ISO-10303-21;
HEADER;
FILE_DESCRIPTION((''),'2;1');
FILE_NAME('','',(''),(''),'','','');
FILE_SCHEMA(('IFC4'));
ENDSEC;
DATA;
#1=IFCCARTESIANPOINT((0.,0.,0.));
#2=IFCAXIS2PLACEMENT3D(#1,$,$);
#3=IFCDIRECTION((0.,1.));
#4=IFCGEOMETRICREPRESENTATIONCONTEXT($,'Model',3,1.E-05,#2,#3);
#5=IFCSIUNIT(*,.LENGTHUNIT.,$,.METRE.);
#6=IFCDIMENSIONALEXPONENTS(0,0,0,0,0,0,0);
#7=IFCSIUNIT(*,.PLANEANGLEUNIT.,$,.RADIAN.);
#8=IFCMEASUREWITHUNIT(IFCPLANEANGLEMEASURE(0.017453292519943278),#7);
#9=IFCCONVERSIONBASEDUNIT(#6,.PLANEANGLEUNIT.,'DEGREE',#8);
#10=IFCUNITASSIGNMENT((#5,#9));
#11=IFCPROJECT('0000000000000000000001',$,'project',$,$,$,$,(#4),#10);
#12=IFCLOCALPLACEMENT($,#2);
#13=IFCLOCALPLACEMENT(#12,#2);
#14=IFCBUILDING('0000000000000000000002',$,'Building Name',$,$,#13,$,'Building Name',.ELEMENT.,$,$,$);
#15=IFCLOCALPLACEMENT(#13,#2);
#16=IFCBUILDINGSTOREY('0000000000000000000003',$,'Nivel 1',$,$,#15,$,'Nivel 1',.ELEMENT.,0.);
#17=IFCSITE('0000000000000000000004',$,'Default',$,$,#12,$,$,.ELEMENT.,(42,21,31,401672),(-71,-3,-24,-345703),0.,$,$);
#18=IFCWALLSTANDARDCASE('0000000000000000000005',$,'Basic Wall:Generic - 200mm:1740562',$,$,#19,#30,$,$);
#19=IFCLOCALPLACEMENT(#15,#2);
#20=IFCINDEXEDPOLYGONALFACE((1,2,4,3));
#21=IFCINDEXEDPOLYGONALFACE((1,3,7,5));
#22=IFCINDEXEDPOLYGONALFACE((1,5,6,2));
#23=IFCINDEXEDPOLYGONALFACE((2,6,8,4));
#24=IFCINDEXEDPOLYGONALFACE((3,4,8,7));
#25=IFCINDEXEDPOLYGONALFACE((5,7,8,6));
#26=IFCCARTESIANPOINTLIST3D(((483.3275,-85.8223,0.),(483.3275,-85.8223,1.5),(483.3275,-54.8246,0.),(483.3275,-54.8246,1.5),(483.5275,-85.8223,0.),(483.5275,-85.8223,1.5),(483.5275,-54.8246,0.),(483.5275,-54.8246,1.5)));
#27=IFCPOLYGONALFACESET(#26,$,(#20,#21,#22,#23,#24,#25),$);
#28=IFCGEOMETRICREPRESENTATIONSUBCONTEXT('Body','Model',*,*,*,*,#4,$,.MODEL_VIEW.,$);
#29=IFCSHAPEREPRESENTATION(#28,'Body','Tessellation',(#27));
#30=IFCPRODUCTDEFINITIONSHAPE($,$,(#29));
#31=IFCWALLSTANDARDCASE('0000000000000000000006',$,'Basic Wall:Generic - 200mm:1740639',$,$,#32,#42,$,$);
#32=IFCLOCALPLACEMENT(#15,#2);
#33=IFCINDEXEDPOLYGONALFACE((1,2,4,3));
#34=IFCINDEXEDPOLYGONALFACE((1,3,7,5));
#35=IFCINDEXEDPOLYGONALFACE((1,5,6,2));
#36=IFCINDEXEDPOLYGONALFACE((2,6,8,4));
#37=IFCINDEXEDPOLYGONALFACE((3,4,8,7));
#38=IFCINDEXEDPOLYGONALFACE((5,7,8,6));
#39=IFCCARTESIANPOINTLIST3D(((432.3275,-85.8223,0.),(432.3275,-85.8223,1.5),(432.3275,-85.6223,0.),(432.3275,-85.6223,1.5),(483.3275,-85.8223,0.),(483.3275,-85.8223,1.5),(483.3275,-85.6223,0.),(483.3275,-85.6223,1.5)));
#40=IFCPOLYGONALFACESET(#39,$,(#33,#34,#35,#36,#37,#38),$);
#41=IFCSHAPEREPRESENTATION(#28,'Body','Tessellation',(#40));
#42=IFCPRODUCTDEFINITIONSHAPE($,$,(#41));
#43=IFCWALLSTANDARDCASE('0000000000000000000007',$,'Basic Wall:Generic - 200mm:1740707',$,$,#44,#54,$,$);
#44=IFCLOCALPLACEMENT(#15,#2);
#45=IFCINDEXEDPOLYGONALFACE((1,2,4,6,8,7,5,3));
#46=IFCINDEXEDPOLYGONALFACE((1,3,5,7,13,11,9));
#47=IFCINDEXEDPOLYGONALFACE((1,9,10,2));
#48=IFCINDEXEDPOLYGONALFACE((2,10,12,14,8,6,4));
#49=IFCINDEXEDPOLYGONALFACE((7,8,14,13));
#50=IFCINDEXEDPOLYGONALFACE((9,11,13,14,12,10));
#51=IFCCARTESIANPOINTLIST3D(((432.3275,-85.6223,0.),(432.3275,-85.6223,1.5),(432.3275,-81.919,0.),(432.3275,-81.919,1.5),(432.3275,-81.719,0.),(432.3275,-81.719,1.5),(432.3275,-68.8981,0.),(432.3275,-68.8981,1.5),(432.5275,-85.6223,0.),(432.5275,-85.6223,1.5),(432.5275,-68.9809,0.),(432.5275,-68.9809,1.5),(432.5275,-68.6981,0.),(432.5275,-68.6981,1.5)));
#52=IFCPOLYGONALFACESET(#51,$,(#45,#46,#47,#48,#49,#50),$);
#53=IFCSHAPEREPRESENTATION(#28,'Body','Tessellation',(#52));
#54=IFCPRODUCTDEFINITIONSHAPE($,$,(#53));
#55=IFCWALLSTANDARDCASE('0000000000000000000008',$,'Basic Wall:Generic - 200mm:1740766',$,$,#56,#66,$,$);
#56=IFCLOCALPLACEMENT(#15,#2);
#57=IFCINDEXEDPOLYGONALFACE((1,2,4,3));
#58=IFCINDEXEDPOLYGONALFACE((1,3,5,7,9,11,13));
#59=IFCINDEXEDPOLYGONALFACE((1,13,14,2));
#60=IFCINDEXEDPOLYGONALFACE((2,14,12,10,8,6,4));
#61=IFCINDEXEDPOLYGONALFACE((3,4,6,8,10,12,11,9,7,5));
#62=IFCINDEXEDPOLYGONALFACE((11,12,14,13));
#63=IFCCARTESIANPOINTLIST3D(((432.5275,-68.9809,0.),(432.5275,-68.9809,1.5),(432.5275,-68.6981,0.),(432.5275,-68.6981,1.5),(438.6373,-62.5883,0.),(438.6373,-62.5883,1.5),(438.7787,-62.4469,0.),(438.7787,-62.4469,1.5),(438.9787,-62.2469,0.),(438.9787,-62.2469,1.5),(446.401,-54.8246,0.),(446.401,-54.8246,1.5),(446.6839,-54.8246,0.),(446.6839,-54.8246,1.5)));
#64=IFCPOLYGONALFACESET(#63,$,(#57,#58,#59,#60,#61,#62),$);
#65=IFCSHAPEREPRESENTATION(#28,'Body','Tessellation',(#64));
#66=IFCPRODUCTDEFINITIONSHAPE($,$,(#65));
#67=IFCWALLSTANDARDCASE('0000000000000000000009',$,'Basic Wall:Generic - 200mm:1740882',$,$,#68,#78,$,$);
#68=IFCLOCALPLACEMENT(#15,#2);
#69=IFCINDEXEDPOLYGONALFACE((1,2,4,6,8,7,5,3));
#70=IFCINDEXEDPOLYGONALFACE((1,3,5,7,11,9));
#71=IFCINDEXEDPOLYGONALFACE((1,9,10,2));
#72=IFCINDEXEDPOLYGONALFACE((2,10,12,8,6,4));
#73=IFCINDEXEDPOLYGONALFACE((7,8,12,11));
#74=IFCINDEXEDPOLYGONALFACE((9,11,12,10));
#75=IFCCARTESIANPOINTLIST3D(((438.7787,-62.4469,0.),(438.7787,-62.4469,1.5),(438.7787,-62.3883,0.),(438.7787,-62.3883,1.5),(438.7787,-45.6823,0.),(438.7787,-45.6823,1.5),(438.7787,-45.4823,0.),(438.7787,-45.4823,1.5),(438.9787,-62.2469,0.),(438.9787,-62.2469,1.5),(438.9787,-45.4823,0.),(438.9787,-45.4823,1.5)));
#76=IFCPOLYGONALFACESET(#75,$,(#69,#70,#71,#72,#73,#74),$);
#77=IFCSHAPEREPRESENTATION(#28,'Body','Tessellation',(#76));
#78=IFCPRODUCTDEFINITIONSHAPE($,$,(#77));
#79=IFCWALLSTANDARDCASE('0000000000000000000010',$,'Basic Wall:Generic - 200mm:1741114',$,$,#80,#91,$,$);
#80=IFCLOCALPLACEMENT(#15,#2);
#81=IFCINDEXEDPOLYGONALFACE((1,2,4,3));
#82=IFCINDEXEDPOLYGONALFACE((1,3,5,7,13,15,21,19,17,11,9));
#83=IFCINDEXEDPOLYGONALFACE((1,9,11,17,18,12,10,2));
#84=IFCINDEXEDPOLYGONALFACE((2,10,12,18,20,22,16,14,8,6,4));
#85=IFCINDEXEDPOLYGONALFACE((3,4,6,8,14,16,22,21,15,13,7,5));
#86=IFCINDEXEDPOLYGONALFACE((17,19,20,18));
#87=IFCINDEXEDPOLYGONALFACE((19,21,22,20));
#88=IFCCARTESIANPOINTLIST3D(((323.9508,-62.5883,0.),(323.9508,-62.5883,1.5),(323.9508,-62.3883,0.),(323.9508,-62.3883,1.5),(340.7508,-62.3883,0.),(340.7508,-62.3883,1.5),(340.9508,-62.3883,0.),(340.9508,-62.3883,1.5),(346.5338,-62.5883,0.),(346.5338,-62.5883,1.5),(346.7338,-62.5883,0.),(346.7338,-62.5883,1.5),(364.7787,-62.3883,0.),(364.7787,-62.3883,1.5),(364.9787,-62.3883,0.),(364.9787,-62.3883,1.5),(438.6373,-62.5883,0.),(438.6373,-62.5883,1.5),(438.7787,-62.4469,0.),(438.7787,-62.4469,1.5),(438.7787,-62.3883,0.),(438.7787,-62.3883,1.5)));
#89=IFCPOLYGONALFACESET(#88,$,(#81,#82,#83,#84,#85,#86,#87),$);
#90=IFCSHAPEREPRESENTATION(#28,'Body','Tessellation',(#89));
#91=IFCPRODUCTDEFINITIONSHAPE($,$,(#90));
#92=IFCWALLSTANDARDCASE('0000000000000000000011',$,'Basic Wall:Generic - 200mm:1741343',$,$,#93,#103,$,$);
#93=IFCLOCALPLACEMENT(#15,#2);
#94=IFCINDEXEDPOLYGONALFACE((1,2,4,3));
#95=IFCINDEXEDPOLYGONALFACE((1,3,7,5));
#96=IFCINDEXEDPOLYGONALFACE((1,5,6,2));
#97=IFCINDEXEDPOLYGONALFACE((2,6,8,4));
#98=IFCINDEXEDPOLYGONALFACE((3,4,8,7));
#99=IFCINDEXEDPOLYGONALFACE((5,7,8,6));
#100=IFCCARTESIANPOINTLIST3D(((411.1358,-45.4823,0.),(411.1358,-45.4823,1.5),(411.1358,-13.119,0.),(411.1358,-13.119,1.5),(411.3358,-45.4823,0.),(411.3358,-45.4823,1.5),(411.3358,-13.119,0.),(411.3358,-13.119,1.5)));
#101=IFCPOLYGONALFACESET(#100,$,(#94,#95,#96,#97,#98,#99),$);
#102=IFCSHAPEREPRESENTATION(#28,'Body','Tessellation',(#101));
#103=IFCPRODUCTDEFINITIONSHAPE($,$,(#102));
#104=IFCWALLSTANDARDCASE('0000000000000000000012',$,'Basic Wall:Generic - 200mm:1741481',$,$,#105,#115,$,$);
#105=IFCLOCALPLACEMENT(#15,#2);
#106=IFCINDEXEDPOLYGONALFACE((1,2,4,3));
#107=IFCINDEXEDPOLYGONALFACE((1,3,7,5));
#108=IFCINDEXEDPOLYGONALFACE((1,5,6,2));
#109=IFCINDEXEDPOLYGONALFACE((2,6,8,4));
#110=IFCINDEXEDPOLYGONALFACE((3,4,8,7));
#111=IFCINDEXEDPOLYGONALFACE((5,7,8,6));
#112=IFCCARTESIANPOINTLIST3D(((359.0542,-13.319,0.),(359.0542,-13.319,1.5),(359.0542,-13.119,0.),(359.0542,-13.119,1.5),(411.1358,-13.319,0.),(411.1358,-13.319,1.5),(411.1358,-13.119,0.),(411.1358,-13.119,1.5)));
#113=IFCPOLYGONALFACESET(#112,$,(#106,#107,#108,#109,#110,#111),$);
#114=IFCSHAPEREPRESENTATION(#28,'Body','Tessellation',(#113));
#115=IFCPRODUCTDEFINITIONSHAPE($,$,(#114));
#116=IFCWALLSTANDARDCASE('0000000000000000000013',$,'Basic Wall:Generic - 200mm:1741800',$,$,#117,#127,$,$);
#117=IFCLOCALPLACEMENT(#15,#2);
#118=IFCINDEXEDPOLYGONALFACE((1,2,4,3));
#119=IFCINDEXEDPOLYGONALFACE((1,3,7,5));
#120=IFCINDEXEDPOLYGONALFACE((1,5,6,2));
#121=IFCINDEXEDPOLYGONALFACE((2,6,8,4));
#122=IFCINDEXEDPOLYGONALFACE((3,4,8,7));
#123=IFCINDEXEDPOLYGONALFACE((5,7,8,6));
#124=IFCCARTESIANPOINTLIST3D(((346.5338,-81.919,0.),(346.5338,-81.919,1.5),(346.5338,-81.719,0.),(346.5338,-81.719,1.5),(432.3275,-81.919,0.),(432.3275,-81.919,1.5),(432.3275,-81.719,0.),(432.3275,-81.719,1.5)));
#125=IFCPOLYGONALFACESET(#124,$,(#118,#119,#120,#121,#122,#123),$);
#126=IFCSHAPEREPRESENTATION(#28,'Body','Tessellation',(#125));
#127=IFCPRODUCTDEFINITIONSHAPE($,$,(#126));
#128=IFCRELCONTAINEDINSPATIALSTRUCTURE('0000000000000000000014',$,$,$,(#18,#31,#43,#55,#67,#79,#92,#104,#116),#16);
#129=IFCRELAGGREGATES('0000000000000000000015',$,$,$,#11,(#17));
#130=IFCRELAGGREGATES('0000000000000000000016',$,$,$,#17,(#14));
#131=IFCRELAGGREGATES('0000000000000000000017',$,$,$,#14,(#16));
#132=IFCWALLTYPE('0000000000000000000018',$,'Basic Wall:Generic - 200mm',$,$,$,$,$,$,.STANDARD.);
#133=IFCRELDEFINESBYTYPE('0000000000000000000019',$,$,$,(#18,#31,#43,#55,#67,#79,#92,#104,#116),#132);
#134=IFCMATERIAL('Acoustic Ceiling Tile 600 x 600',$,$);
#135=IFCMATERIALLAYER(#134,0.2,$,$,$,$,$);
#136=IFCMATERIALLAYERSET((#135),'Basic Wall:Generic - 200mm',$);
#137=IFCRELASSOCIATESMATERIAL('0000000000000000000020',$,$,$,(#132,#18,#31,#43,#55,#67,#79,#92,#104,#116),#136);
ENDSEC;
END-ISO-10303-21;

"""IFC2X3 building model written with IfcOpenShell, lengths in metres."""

from ifc_helpers import new_model, entity, si_unit, converted_unit, direction, frame, frame_2d, origin, place, context, subcontext, project, spatial, polyline, rectangle, outline, extrude, material, layer, layer_set, layer_usage, type_object, element, save


model = new_model("IFC2X3")

# Units and contexts
model_context = context("Model", 3, precision=1e-05, world=origin(), true_north=direction((0.0, 1.0)))
body_context = subcontext(model_context, "Body", "Model", "MODEL_VIEW")
ifc_project = project(units=[si_unit("LENGTHUNIT", "METRE"), converted_unit("PLANEANGLEUNIT", "DEGREE", entity("IfcPlaneAngleMeasure", 0.017453292519943278), si_unit("PLANEANGLEUNIT", "RADIAN"), dimensions=[0, 0, 0, 0, 0, 0, 0])], contexts=[model_context])

# Site, building, storey
site_placement = place(None, origin())
site = spatial("IfcSite", under=ifc_project, at=site_placement, Name="Default", CompositionType="ELEMENT", RefLatitude=(42, 21, 31, 401672), RefLongitude=(-71, -3, -24, -345703), RefElevation=0.0)
building_placement = place(site_placement, origin())
building = spatial("IfcBuilding", under=site, at=building_placement, Name="Building Name", LongName="Building Name", CompositionType="ELEMENT")
storey_placement = place(building_placement, origin())
storey = spatial("IfcBuildingStorey", under=building, at=storey_placement, Name="Nivel 1", LongName="Nivel 1", CompositionType="ELEMENT", Elevation=0.0)

# Walls
ifc_material_1 = material(Name="Acoustic Ceiling Tile 600 x 600")
ifc_layer = layer(ifc_material_1, 0.2)
ifc_layer_set = layer_set([ifc_layer], Name="Basic Wall:Generic - 200mm")
wall_type_1 = type_object("IfcWallType", Name="Basic Wall:Generic - 200mm", PredefinedType="STANDARD", material=ifc_layer_set)
ifc_layer_usage_1 = layer_usage(ifc_layer_set, "AXIS2", "NEGATIVE", 0.1)
wall_1_placement = place(storey_placement, frame((483.4275, -54.8246, 0.0), z_axis=(0.0, 0.0, 1.0), x_axis=(0.0, -1.0, 0.0)))
element("IfcWallStandardCase", 1, at=wall_1_placement, inside=storey, type_object=wall_type_1, material=ifc_layer_usage_1, Name="Basic Wall:Generic - 200mm:1740562", context=body_context, shape_type="SweptSolid", body=[
    extrude(rectangle(XDim=30.9978, YDim=0.2, at=frame_2d((15.4989, 0.0), x_axis=(-1.0, 0.0))), origin(), (0.0, 0.0, 1.0), 1.5),
])
ifc_layer_usage_2 = layer_usage(ifc_layer_set, "AXIS2", "NEGATIVE", 0.1)
wall_2_placement = place(storey_placement, frame((483.3275, -85.7223, 0.0), z_axis=(0.0, 0.0, 1.0), x_axis=(-1.0, 0.0, 0.0)))
element("IfcWallStandardCase", 2, at=wall_2_placement, inside=storey, type_object=wall_type_1, material=ifc_layer_usage_2, Name="Basic Wall:Generic - 200mm:1740639", context=body_context, shape_type="SweptSolid", body=[
    extrude(rectangle(XDim=51.0, YDim=0.2, at=frame_2d((25.5, 0.0), x_axis=(-1.0, 0.0))), origin(), (0.0, 0.0, 1.0), 1.5),
])
ifc_layer_usage_3 = layer_usage(ifc_layer_set, "AXIS2", "NEGATIVE", 0.1)
wall_3_placement = place(storey_placement, frame((432.4275, -85.6223, 0.0), z_axis=(0.0, 0.0, 1.0), x_axis=(0.0, 1.0, 0.0)))
element("IfcWallStandardCase", 3, at=wall_3_placement, inside=storey, type_object=wall_type_1, material=ifc_layer_usage_3, Name="Basic Wall:Generic - 200mm:1740707", context=body_context, shape_type="SweptSolid", body=[
    extrude(outline(polyline([(16.9243, -0.1), (16.7243, 0.1), (3.9033, 0.1), (3.7033, 0.1), (0.0, 0.1), (0.0, -0.1), (16.6414, -0.1), (16.9243, -0.1)])), origin(), (0.0, 0.0, 1.0), 1.5),
])
ifc_layer_usage_4 = layer_usage(ifc_layer_set, "AXIS2", "NEGATIVE", 0.1)
wall_4_placement = place(storey_placement, frame((432.4568, -68.9102, 0.0), z_axis=(0.0, 0.0, 1.0), x_axis=(0.707107, 0.707107, 0.0)))
element("IfcWallStandardCase", 4, at=wall_4_placement, inside=storey, type_object=wall_type_1, material=ifc_layer_usage_4, Name="Basic Wall:Generic - 200mm:1740766", context=body_context, shape_type="SweptSolid", body=[
    extrude(outline(polyline([(20.0201, -0.1), (19.8201, 0.1), (9.3234, 0.1), (9.0406, 0.1), (8.8406, 0.1), (0.2, 0.1), (0.0, -0.1), (20.0201, -0.1)])), origin(), (0.0, 0.0, 1.0), 1.5),
])
ifc_layer_usage_5 = layer_usage(ifc_layer_set, "AXIS2", "NEGATIVE", 0.1)
wall_5_placement = place(storey_placement, frame((438.8787, -45.4823, 0.0), z_axis=(0.0, 0.0, 1.0), x_axis=(0.0, -1.0, 0.0)))
element("IfcWallStandardCase", 5, at=wall_5_placement, inside=storey, type_object=wall_type_1, material=ifc_layer_usage_5, Name="Basic Wall:Generic - 200mm:1740882", context=body_context, shape_type="SweptSolid", body=[
    extrude(outline(polyline([(16.9646, -0.1), (16.7646, 0.1), (0.0, 0.1), (0.0, -0.1), (0.2, -0.1), (16.906, -0.1), (16.9646, -0.1)])), origin(), (0.0, 0.0, 1.0), 1.5),
])
ifc_layer_usage_6 = layer_usage(ifc_layer_set, "AXIS2", "NEGATIVE", 0.1)
wall_6_placement = place(storey_placement, frame((438.7787, -62.4883, 0.0), z_axis=(0.0, 0.0, 1.0), x_axis=(-1.0, 0.0, 0.0)))
element("IfcWallStandardCase", 6, at=wall_6_placement, inside=storey, type_object=wall_type_1, material=ifc_layer_usage_6, Name="Basic Wall:Generic - 200mm:1741114", context=body_context, shape_type="SweptSolid", body=[
    extrude(outline(polyline([(114.8279, -0.1), (114.8279, 0.1), (92.2449, 0.1), (92.0449, 0.1), (0.1414, 0.1), (0.0, -0.0414), (0.0, -0.1), (73.8, -0.1), (74.0, -0.1), (97.8279, -0.1), (98.0279, -0.1), (114.8279, -0.1)])), origin(), (0.0, 0.0, 1.0), 1.5),
])
ifc_layer_usage_7 = layer_usage(ifc_layer_set, "AXIS2", "NEGATIVE", 0.1)
wall_7_placement = place(storey_placement, frame((411.2358, -45.4823, 0.0), z_axis=(0.0, 0.0, 1.0), x_axis=(0.0, 1.0, 0.0)))
element("IfcWallStandardCase", 7, at=wall_7_placement, inside=storey, type_object=wall_type_1, material=ifc_layer_usage_7, Name="Basic Wall:Generic - 200mm:1741343", context=body_context, shape_type="SweptSolid", body=[
    extrude(rectangle(XDim=32.3633, YDim=0.2, at=frame_2d((16.1816, 0.0), x_axis=(-1.0, 0.0))), origin(), (0.0, 0.0, 1.0), 1.5),
])
ifc_layer_usage_8 = layer_usage(ifc_layer_set, "AXIS2", "NEGATIVE", 0.1)
wall_8_placement = place(storey_placement, frame((411.1358, -13.219, 0.0), z_axis=(0.0, 0.0, 1.0), x_axis=(-1.0, 0.0, 0.0)))
element("IfcWallStandardCase", 8, at=wall_8_placement, inside=storey, type_object=wall_type_1, material=ifc_layer_usage_8, Name="Basic Wall:Generic - 200mm:1741481", context=body_context, shape_type="SweptSolid", body=[
    extrude(rectangle(XDim=52.0816, YDim=0.2, at=frame_2d((26.0408, 0.0), x_axis=(-1.0, 0.0))), origin(), (0.0, 0.0, 1.0), 1.5),
])
ifc_layer_usage_9 = layer_usage(ifc_layer_set, "AXIS2", "NEGATIVE", 0.1)
wall_9_placement = place(storey_placement, frame((432.3275, -81.819, 0.0), z_axis=(0.0, 0.0, 1.0), x_axis=(-1.0, 0.0, 0.0)))
element("IfcWallStandardCase", 9, at=wall_9_placement, inside=storey, type_object=wall_type_1, material=ifc_layer_usage_9, Name="Basic Wall:Generic - 200mm:1741800", context=body_context, shape_type="SweptSolid", body=[
    extrude(rectangle(XDim=85.7937, YDim=0.2, at=frame_2d((42.8968, 0.0), x_axis=(-1.0, 0.0))), origin(), (0.0, 0.0, 1.0), 1.5),
])

save(model, "model.ifc")
